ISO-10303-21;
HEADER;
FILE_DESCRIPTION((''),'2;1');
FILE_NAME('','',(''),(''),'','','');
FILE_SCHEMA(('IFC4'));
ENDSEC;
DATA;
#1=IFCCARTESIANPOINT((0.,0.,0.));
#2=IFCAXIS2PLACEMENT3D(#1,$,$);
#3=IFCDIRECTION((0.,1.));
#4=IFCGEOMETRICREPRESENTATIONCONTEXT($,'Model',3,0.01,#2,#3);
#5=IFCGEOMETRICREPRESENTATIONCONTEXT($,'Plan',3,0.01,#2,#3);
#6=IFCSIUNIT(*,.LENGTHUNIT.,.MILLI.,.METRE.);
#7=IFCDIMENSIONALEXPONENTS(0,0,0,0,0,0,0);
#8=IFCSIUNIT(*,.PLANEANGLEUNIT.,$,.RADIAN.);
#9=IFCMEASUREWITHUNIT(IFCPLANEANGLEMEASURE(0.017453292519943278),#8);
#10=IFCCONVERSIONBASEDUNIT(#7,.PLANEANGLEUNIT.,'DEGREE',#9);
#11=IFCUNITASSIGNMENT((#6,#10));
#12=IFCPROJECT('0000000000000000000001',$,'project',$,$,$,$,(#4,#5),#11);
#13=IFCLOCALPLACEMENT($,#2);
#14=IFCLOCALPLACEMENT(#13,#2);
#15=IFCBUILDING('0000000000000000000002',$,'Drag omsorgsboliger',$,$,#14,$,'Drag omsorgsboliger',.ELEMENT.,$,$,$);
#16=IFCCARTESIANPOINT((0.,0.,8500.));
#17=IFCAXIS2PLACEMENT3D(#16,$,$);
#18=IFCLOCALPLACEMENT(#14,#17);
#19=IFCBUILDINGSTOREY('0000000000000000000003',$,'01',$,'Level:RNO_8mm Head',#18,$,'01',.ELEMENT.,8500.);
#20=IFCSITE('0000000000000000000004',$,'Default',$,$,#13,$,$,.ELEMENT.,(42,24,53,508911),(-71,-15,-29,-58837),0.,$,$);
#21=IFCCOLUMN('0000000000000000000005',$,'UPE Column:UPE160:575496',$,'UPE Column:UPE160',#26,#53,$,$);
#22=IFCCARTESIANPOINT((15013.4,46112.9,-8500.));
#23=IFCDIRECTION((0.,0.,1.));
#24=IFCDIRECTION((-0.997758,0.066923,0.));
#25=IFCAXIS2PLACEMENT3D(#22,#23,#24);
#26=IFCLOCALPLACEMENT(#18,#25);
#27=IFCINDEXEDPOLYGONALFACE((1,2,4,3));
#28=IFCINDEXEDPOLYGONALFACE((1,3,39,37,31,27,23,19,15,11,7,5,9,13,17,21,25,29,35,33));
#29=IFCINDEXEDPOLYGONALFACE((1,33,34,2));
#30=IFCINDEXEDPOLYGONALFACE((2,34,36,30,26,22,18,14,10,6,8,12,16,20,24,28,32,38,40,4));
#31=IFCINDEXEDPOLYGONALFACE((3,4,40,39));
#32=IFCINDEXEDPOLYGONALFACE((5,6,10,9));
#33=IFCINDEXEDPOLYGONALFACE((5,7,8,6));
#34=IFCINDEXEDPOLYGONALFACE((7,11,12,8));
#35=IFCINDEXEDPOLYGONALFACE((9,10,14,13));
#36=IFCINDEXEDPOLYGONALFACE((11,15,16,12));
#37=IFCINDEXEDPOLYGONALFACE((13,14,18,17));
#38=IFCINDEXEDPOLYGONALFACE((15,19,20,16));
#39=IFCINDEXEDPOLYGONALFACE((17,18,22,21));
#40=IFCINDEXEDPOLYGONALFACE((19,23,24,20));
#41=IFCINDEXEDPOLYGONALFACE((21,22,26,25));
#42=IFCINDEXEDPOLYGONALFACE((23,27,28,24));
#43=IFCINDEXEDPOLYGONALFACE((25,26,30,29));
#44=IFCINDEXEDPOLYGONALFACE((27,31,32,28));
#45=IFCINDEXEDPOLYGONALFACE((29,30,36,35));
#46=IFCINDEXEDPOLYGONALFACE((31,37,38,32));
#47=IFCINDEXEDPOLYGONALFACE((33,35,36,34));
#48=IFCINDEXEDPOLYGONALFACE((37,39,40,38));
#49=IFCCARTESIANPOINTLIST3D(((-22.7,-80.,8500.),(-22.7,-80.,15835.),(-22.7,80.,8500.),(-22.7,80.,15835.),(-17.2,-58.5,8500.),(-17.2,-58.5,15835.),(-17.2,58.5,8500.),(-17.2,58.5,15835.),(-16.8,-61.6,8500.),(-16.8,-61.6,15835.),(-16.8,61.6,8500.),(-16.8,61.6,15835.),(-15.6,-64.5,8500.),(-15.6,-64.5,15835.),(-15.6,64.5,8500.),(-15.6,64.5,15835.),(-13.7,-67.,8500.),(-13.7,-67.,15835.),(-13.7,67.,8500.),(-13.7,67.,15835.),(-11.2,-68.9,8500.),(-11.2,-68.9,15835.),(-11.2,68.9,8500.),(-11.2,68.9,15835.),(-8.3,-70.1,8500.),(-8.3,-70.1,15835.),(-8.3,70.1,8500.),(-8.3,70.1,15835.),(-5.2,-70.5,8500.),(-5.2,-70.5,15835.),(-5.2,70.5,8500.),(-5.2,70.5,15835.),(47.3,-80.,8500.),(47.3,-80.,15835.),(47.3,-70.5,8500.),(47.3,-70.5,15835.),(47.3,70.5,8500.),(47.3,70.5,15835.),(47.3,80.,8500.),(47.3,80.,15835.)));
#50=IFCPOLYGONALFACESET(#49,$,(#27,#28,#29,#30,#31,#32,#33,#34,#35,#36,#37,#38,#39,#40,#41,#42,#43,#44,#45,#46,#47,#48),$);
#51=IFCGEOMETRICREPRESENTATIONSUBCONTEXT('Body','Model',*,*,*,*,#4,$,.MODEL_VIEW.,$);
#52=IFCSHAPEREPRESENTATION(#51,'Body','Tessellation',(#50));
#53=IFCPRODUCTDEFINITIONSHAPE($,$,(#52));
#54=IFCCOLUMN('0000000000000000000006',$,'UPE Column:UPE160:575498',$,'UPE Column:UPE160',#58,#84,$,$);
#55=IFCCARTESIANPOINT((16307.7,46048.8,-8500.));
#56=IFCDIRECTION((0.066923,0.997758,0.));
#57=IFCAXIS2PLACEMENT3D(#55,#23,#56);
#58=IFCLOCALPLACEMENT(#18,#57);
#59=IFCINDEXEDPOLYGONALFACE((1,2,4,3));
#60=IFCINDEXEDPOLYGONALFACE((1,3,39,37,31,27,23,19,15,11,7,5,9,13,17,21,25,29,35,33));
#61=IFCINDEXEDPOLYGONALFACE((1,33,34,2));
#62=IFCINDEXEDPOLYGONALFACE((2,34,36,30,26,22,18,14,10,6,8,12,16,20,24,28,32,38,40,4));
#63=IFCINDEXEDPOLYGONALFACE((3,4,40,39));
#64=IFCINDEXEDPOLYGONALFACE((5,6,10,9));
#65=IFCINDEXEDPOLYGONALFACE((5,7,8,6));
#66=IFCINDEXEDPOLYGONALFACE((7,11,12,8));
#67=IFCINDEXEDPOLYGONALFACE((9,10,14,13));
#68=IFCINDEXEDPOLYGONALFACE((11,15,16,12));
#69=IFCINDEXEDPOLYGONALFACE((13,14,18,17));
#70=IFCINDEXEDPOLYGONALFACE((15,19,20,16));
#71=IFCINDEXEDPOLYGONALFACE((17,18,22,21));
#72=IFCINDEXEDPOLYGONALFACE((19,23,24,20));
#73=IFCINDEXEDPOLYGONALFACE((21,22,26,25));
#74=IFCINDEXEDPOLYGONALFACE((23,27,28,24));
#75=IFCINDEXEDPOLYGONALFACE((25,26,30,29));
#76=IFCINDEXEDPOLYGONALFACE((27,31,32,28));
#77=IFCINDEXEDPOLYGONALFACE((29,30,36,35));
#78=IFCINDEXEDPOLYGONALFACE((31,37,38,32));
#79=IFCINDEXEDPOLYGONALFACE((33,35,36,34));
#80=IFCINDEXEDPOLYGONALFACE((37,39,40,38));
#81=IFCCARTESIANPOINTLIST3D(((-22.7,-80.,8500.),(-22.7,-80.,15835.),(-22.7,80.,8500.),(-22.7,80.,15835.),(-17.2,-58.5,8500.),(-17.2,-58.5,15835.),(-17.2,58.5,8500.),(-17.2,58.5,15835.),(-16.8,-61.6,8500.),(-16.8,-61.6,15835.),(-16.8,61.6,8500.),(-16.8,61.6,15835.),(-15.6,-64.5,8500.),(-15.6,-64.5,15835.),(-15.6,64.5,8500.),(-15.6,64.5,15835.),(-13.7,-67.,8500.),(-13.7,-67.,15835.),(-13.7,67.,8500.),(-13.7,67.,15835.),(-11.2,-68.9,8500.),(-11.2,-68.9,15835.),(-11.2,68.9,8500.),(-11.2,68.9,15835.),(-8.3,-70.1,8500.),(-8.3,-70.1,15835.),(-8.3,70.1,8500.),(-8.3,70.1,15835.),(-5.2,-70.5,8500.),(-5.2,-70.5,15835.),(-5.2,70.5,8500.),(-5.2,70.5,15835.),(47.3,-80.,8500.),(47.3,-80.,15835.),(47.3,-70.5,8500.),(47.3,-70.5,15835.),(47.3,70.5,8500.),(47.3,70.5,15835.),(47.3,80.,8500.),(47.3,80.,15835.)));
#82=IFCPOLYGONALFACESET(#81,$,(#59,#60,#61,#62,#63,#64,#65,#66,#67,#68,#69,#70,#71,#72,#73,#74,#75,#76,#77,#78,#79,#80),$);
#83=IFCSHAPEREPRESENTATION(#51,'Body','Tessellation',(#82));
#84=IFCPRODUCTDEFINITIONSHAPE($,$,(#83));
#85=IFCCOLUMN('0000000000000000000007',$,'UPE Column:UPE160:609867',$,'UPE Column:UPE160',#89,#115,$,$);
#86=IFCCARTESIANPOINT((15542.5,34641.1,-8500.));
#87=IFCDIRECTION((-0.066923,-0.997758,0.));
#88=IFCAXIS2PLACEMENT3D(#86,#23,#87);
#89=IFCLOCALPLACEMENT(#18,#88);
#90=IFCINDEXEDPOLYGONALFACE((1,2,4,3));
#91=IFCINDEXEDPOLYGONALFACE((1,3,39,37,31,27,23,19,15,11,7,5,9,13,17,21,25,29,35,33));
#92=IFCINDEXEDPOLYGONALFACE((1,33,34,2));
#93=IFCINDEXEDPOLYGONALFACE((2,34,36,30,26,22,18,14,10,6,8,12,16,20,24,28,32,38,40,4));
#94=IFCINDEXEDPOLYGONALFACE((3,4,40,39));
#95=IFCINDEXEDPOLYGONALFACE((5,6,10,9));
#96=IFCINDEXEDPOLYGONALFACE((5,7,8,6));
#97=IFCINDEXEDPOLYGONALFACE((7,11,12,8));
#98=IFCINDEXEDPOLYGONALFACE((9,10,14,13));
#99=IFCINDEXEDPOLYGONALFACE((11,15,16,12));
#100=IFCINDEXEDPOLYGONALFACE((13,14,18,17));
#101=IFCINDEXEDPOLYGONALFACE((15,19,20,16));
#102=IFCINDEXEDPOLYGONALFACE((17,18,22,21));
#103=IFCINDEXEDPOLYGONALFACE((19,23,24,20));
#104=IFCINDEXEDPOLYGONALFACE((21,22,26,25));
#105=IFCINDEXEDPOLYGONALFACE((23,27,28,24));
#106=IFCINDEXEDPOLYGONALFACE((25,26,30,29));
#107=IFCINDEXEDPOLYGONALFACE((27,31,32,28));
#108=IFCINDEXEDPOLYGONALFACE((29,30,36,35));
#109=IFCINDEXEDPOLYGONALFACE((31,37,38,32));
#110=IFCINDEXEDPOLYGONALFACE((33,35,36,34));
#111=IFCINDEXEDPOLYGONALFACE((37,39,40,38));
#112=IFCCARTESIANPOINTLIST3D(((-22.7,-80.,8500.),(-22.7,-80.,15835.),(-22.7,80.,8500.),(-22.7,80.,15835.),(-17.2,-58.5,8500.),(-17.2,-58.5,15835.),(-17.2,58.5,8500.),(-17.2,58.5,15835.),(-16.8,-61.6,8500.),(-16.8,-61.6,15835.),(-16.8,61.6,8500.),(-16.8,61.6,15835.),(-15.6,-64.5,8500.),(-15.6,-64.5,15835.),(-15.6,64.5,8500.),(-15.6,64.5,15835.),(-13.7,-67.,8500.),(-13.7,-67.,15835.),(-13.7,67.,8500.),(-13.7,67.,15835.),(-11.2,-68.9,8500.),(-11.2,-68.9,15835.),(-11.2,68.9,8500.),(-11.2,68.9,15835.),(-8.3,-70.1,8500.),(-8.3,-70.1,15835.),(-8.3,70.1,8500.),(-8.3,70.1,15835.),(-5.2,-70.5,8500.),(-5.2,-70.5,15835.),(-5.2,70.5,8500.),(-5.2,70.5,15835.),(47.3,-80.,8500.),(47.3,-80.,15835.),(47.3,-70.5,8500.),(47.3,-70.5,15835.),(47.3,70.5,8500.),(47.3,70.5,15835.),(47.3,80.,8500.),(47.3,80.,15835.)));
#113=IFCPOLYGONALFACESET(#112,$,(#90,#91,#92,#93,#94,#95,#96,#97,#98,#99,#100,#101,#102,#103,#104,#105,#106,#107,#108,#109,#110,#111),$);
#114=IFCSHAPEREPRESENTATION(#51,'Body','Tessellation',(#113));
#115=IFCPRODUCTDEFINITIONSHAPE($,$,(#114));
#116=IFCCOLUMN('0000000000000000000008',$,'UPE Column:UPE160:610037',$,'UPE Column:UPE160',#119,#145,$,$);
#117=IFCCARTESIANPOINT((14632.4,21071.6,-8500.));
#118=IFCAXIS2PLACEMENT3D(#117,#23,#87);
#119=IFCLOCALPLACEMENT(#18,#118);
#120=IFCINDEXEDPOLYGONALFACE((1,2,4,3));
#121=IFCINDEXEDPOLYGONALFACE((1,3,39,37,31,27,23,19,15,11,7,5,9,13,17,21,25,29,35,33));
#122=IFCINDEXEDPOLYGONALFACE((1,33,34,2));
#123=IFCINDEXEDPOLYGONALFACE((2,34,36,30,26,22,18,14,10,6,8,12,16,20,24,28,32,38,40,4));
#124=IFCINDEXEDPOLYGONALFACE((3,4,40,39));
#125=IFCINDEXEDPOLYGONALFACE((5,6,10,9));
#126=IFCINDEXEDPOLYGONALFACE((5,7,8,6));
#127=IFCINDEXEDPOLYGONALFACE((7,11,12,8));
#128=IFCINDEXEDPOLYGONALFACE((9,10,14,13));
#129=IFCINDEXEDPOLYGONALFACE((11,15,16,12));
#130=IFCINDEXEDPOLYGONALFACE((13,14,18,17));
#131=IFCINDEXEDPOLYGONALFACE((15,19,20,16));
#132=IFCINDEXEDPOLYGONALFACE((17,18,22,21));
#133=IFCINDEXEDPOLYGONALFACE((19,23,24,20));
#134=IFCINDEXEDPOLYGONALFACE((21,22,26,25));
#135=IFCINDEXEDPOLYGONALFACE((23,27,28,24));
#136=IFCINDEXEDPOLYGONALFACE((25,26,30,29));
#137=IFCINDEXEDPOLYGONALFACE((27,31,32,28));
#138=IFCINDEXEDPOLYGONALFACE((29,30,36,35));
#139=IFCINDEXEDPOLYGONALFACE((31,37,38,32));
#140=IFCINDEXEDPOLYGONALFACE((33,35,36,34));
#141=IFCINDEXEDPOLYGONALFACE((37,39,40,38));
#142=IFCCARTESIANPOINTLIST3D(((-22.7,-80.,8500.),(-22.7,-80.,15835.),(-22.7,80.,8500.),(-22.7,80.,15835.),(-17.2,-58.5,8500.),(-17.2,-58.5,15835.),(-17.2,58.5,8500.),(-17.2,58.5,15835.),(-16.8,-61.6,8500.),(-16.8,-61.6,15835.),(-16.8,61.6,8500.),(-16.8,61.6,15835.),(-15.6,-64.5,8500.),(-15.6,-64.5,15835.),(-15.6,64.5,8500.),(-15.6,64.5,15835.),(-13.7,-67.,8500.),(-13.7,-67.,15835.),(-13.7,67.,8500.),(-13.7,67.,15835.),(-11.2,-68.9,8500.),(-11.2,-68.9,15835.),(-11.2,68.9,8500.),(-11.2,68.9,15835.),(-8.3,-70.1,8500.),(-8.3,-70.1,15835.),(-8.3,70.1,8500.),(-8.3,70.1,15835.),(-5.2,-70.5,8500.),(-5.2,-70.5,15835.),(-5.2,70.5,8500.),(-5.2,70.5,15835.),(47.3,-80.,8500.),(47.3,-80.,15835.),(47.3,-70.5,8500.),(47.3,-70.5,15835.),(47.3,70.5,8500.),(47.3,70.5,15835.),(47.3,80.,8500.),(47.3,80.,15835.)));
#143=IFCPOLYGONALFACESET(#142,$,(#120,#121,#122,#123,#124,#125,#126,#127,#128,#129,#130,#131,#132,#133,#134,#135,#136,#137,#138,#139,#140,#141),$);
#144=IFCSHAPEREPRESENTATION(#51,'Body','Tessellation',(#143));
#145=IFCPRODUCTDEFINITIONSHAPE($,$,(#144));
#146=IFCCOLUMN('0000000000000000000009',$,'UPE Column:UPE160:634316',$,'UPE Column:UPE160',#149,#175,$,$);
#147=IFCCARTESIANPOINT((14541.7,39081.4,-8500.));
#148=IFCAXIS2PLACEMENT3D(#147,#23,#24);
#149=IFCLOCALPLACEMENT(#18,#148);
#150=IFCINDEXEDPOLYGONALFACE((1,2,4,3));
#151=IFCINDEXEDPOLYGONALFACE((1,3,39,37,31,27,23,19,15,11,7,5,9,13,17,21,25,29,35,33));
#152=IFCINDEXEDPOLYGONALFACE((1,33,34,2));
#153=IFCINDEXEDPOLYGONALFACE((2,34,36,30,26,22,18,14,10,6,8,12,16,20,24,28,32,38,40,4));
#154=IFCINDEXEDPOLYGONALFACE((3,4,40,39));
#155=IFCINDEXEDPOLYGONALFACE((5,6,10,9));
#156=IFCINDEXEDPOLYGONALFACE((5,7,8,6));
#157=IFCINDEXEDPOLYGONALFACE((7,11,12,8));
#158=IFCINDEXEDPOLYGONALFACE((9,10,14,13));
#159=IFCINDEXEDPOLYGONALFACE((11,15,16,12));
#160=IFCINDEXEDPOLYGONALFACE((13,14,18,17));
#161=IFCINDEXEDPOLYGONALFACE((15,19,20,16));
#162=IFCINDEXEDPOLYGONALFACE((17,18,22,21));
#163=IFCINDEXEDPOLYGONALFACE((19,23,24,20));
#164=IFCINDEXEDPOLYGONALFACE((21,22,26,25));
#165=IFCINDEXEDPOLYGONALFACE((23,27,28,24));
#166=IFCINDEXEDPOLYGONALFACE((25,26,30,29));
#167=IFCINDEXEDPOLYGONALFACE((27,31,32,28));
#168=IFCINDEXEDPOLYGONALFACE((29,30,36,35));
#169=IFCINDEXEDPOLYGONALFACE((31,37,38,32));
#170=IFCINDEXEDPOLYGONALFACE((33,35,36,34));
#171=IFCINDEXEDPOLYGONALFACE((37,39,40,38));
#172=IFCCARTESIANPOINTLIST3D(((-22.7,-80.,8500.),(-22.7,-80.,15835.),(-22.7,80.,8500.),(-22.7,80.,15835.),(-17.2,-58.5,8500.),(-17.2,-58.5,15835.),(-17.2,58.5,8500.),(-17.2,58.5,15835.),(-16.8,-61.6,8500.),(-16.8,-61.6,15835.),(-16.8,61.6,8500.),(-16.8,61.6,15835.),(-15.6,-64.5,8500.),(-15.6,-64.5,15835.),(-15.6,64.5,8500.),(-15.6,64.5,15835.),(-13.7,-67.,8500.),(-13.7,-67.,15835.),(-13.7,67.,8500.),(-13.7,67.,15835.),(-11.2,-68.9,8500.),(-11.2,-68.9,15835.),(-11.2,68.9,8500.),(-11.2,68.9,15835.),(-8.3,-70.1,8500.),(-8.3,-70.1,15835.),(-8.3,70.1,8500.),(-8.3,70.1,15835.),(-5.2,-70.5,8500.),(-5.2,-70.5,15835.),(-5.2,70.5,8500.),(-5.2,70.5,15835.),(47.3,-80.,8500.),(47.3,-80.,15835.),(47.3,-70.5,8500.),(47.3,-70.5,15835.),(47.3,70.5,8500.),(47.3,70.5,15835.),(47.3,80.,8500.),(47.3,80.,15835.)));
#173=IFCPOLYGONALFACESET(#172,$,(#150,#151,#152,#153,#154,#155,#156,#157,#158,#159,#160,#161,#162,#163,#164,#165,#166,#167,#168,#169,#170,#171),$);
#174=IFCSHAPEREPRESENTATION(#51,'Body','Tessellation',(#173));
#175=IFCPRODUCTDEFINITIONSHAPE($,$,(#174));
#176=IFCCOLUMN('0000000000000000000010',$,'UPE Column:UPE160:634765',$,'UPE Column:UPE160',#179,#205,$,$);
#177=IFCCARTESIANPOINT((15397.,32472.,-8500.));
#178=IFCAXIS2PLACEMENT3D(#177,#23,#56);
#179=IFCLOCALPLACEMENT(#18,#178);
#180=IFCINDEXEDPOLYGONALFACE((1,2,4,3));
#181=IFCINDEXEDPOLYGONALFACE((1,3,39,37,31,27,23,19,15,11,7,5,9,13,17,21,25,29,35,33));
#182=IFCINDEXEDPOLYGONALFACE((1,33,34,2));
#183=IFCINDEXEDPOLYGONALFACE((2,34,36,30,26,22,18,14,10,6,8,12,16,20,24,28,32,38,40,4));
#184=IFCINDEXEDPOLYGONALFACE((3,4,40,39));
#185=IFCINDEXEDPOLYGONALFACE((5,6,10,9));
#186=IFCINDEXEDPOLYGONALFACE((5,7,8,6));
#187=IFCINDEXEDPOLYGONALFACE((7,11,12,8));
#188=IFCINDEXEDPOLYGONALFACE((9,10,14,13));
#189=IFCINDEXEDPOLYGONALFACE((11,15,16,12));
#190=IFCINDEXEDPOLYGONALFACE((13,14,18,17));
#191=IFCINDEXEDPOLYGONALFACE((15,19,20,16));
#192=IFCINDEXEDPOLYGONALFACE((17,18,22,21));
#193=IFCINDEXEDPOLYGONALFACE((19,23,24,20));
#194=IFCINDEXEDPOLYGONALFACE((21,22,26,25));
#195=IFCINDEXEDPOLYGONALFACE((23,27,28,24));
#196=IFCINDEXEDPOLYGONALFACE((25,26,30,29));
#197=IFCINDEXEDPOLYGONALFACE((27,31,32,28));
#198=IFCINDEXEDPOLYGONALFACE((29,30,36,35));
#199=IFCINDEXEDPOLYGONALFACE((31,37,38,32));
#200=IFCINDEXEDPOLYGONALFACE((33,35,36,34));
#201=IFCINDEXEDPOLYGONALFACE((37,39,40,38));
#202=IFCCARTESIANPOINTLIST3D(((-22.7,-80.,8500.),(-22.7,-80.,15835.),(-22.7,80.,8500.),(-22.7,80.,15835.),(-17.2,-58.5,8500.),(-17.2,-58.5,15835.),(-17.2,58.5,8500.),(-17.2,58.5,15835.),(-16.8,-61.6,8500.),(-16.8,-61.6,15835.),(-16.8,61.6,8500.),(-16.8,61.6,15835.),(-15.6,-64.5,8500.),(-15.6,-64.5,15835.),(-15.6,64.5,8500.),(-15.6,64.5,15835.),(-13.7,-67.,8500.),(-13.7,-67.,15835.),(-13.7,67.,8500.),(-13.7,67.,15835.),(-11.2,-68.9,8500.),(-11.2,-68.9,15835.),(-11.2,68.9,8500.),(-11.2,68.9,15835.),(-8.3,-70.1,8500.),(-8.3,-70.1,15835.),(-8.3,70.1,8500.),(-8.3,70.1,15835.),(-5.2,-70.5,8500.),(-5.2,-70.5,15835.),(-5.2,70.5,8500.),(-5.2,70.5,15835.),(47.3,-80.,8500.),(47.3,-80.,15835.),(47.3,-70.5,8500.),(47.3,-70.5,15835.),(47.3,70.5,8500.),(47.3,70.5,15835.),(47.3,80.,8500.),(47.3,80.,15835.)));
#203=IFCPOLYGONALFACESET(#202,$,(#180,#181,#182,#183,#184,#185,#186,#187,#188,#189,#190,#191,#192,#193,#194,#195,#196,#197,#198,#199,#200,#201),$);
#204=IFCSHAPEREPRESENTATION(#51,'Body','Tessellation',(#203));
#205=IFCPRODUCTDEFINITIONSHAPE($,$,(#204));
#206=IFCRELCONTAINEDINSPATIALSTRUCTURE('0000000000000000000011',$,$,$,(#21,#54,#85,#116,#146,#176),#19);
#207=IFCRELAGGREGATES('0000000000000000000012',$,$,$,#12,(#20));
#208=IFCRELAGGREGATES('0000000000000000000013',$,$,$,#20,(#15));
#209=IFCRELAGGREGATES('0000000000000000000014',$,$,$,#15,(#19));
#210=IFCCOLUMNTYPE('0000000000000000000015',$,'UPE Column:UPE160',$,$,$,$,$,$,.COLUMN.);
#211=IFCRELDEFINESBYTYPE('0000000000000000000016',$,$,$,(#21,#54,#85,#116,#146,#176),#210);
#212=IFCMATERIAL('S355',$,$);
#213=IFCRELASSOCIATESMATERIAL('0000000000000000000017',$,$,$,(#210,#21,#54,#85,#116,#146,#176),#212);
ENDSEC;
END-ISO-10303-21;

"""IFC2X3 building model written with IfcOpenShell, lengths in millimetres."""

from ifc_helpers import new_model, entity, si_unit, converted_unit, direction, frame, frame_2d, origin, place, context, subcontext, project, spatial, polyline, circle_curve, parameter, trimmed, segment, composite_curve, outline, extrude, source, transform, mapped, material, type_object, type_shapes, element, save


model = new_model("IFC2X3")

# Units and contexts
model_context = context("Model", 3, precision=0.01, world=origin(), true_north=direction((0.0, 1.0)))
plan_context = context("Plan", 3, precision=0.01, world=origin(), true_north=direction((0.0, 1.0)))
body_context = subcontext(model_context, "Body", "Model", "MODEL_VIEW")
ifc_project = project(units=[si_unit("LENGTHUNIT", "METRE", prefix="MILLI"), converted_unit("PLANEANGLEUNIT", "DEGREE", entity("IfcPlaneAngleMeasure", 0.017453292519943278), si_unit("PLANEANGLEUNIT", "RADIAN"), dimensions=[0, 0, 0, 0, 0, 0, 0])], contexts=[model_context, plan_context])

# Site, building, storey
site_placement = place(None, origin())
site = spatial("IfcSite", under=ifc_project, at=site_placement, Name="Default", CompositionType="ELEMENT", RefLatitude=(42, 24, 53, 508911), RefLongitude=(-71, -15, -29, -58837), RefElevation=0.0)
building_placement = place(site_placement, origin())
building = spatial("IfcBuilding", under=site, at=building_placement, Name="Drag omsorgsboliger", LongName="Drag omsorgsboliger", CompositionType="ELEMENT")
storey_placement = place(building_placement, frame((0.0, 0.0, 8500.0)))
storey = spatial("IfcBuildingStorey", under=building, at=storey_placement, Name="01", ObjectType="Level:RNO_8mm Head", LongName="01", CompositionType="ELEMENT", Elevation=8500.0)

# Columns
ifc_material_1 = material(Name="S355")
column_type_1 = type_object("IfcColumnType", Name="UPE Column:UPE160", PredefinedType="COLUMN", material=ifc_material_1)
shared_shape_1 = source(origin(), body_context, "Body", "SweptSolid", [
    extrude(outline(composite_curve([segment(polyline([(-37.4, -80.0), (32.6, -80.0)]), True, "CONTINUOUS"), segment(polyline([(32.6, -80.0), (32.6, 80.0)]), True, "CONTINUOUS"), segment(polyline([(32.6, 80.0), (-37.4, 80.0)]), True, "CONTINUOUS"), segment(polyline([(-37.4, 80.0), (-37.4, 70.5)]), True, "CONTINUOUS"), segment(polyline([(-37.4, 70.5), (15.1, 70.5)]), True, "CONTINUOUS"), segment(trimmed(circle_curve(frame_2d((15.1, 58.5), x_axis=(-1.0, 0.0)), 12.0), [parameter(180.0)], [parameter(270.0)], True, "PARAMETER"), False, "CONTINUOUS"), segment(polyline([(27.1, 58.5), (27.1, -58.5)]), True, "CONTINUOUS"), segment(trimmed(circle_curve(frame_2d((15.1, -58.5), x_axis=(-1.0, 0.0)), 12.0), [parameter(90.0)], [parameter(180.0)], True, "PARAMETER"), False, "CONTINUOUS"), segment(polyline([(15.1, -70.5), (-37.4, -70.5)]), True, "CONTINUOUS"), segment(polyline([(-37.4, -70.5), (-37.4, -80.0)]), True, "CONTINUOUS")], self_intersect=False)), frame((9.9, 0.0, 8500.0), z_axis=(0.0, 0.0, 1.0), x_axis=(-1.0, 0.0, 0.0)), (0.0, 0.0, 1.0), 7335.0),
])
type_shapes(column_type_1, [shared_shape_1])
for number, where, z_axis, x_axis, name in (
    (1, (15013.4, 46112.9, -8500.0), (0.0, 0.0, 1.0), (-0.997758, 0.066923, 0.0), "UPE Column:UPE160:575496"),
    (2, (16307.7, 46048.8, -8500.0), (0.0, 0.0, 1.0), (0.066923, 0.997758, 0.0), "UPE Column:UPE160:575498"),
    (3, (15542.5, 34641.1, -8500.0), (0.0, 0.0, 1.0), (-0.066923, -0.997758, 0.0), "UPE Column:UPE160:609867"),
    (4, (14632.4, 21071.6, -8500.0), (0.0, 0.0, 1.0), (-0.066923, -0.997758, 0.0), "UPE Column:UPE160:610037"),
    (5, (14541.7, 39081.4, -8500.0), (0.0, 0.0, 1.0), (-0.997758, 0.066923, 0.0), "UPE Column:UPE160:634316"),
    (6, (15397.0, 32472.0, -8500.0), (0.0, 0.0, 1.0), (0.066923, 0.997758, 0.0), "UPE Column:UPE160:634765"),
):
    element("IfcColumn", number, at=place(storey_placement, frame(where, z_axis=z_axis, x_axis=x_axis)), inside=storey, type_object=column_type_1, material=ifc_material_1, Name=name, ObjectType="UPE Column:UPE160", context=body_context, shape_type="MappedRepresentation", body=[
        mapped(shared_shape_1, transform((0.0, 0.0, 0.0), scale=1.0)),
    ])

save(model, "model.ifc")
